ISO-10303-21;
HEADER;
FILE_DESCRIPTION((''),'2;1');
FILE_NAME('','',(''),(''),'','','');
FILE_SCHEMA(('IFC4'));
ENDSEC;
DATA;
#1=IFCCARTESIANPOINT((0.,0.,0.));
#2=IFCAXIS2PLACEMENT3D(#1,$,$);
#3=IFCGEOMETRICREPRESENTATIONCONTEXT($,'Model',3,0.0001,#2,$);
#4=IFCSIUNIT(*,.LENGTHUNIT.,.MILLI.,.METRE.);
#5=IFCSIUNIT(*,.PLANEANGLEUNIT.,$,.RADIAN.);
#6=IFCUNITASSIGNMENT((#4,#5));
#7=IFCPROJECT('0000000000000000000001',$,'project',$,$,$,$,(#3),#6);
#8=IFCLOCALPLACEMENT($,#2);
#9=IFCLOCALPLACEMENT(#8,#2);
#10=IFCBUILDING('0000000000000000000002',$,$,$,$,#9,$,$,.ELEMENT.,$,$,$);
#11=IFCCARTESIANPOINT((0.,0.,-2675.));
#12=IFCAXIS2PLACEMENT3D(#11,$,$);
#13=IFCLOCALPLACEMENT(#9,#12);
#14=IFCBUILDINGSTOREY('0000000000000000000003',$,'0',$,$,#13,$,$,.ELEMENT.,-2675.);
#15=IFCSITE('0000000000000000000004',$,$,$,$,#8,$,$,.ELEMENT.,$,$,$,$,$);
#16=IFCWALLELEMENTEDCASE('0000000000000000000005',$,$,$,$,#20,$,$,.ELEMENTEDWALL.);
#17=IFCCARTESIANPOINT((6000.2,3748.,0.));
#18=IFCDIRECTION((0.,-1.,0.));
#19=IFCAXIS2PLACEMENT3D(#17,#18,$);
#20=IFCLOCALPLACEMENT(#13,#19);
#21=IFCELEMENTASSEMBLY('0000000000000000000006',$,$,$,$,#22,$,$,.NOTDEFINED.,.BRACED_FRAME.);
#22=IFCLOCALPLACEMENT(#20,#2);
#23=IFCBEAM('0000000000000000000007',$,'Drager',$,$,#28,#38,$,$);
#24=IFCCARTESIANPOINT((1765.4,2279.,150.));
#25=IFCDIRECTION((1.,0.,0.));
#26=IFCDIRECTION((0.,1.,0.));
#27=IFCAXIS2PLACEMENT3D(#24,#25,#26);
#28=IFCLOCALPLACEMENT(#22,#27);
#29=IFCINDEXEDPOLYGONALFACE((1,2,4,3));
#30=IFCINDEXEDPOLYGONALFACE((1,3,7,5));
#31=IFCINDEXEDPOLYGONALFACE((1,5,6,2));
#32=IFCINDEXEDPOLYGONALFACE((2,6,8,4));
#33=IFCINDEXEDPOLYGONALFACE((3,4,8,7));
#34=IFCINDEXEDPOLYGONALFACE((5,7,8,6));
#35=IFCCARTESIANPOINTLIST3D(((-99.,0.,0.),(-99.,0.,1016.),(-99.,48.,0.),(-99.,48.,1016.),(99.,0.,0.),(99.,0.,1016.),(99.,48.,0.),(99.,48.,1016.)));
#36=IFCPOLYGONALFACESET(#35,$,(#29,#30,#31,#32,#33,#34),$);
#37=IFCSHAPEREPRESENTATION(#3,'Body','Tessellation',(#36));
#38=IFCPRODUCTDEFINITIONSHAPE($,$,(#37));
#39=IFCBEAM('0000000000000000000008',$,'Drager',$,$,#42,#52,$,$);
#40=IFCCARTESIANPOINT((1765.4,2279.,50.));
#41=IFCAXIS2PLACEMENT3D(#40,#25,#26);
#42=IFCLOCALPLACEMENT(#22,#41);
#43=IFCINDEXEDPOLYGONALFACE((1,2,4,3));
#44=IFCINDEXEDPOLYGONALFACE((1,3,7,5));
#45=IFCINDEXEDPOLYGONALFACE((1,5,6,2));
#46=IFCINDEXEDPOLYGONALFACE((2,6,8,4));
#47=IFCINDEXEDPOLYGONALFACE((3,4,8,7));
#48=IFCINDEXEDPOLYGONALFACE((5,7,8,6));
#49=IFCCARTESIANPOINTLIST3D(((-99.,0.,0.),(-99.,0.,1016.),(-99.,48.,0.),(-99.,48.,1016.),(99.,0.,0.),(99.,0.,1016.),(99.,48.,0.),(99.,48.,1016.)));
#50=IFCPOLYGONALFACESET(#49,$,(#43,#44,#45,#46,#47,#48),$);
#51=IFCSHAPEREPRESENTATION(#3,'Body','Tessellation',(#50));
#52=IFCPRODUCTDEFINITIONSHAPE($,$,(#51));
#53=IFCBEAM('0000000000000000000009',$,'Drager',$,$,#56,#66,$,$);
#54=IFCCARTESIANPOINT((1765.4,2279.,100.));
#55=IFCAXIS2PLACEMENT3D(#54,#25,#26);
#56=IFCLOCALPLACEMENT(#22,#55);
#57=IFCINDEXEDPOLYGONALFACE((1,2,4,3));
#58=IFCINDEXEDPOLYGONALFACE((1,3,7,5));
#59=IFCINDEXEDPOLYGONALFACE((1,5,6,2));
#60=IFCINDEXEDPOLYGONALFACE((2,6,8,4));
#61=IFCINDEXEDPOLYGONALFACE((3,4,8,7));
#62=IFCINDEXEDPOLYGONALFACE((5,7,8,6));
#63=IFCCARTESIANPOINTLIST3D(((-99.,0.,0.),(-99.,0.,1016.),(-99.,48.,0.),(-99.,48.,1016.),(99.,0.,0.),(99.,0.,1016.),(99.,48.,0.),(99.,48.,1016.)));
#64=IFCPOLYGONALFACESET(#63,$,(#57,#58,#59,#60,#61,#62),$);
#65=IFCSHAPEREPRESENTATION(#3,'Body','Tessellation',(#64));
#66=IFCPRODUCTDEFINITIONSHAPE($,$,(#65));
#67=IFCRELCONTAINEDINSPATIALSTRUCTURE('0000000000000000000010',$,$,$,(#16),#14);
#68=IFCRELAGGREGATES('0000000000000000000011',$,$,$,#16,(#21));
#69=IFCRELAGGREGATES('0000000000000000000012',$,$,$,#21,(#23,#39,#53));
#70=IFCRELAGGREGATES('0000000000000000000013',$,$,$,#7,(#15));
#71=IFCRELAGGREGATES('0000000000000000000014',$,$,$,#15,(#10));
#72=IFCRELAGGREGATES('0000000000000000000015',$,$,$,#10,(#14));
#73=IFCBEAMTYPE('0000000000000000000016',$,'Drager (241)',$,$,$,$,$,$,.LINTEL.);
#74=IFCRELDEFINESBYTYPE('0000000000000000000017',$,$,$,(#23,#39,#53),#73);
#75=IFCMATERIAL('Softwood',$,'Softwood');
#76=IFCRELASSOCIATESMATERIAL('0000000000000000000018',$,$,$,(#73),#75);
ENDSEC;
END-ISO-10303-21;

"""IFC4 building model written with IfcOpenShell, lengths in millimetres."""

from ifc_helpers import new_model, si_unit, frame, origin, place, context, project, spatial, rectangle, extrude, material, material_profile, profile_set, type_object, element, aggregate, save


model = new_model("IFC4")

# Units and contexts
model_context = context("Model", 3, precision=0.0001, world=origin())
ifc_project = project(units=[si_unit("LENGTHUNIT", "METRE", prefix="MILLI"), si_unit("PLANEANGLEUNIT", "RADIAN")], contexts=[model_context])

# Site, building, storey
site_placement = place(None, origin())
site = spatial("IfcSite", under=ifc_project, at=site_placement, CompositionType="ELEMENT")
building_placement = place(site_placement, origin())
building = spatial("IfcBuilding", under=site, at=building_placement, CompositionType="ELEMENT")
storey_placement = place(building_placement, frame((0.0, 0.0, -2675.0)))
storey = spatial("IfcBuildingStorey", under=building, at=storey_placement, Name="0", CompositionType="ELEMENT", Elevation=-2675.0)

# Wall, element assembly
wall_1_placement = place(storey_placement, frame((6000.2, 3748.0, 0.0), z_axis=(0.0, -1.0, 0.0)))
wall_1 = element("IfcWallElementedCase", 1, at=wall_1_placement, inside=storey, PredefinedType="ELEMENTEDWALL")
assembly_1_placement = place(wall_1_placement, origin())
assembly_1 = element("IfcElementAssembly", 2, at=assembly_1_placement, AssemblyPlace="NOTDEFINED", PredefinedType="BRACED_FRAME")
aggregate(wall_1, [assembly_1])

# Beams
ifc_material_1 = material(Name="Softwood", Category="Softwood")
ifc_material_profile_1 = material_profile(ifc_material_1, rectangle(XDim=198.0, YDim=48.0), Name="Drager (241)")
ifc_profile_set_1 = profile_set([ifc_material_profile_1])
beam_type = type_object("IfcBeamType", Name="Drager (241)", PredefinedType="LINTEL", material=ifc_profile_set_1)
beam_1_placement = place(assembly_1_placement, frame((1765.4, 2279.0, 150.0), z_axis=(1.0, 0.0, 0.0), x_axis=(0.0, 1.0, 0.0)))
beam_1 = element("IfcBeam", 3, at=beam_1_placement, type_object=beam_type, Name="Drager", context=model_context, shape_type="SweptSolid", body=[
    extrude(rectangle(XDim=198.0, YDim=48.0), frame((0.0, 24.0, 0.0)), (0.0, 0.0, 1.0), 1016.0),
])
beam_2_placement = place(assembly_1_placement, frame((1765.4, 2279.0, 50.0), z_axis=(1.0, 0.0, 0.0), x_axis=(0.0, 1.0, 0.0)))
beam_2 = element("IfcBeam", 4, at=beam_2_placement, type_object=beam_type, Name="Drager", context=model_context, shape_type="SweptSolid", body=[
    extrude(rectangle(XDim=198.0, YDim=48.0), frame((0.0, 24.0, 0.0)), (0.0, 0.0, 1.0), 1016.0),
])
beam_3_placement = place(assembly_1_placement, frame((1765.4, 2279.0, 100.0), z_axis=(1.0, 0.0, 0.0), x_axis=(0.0, 1.0, 0.0)))
beam_3 = element("IfcBeam", 5, at=beam_3_placement, type_object=beam_type, Name="Drager", context=model_context, shape_type="SweptSolid", body=[
    extrude(rectangle(XDim=198.0, YDim=48.0), frame((0.0, 24.0, 0.0)), (0.0, 0.0, 1.0), 1016.0),
])
aggregate(assembly_1, [beam_1, beam_2, beam_3])

save(model, "model.ifc")
